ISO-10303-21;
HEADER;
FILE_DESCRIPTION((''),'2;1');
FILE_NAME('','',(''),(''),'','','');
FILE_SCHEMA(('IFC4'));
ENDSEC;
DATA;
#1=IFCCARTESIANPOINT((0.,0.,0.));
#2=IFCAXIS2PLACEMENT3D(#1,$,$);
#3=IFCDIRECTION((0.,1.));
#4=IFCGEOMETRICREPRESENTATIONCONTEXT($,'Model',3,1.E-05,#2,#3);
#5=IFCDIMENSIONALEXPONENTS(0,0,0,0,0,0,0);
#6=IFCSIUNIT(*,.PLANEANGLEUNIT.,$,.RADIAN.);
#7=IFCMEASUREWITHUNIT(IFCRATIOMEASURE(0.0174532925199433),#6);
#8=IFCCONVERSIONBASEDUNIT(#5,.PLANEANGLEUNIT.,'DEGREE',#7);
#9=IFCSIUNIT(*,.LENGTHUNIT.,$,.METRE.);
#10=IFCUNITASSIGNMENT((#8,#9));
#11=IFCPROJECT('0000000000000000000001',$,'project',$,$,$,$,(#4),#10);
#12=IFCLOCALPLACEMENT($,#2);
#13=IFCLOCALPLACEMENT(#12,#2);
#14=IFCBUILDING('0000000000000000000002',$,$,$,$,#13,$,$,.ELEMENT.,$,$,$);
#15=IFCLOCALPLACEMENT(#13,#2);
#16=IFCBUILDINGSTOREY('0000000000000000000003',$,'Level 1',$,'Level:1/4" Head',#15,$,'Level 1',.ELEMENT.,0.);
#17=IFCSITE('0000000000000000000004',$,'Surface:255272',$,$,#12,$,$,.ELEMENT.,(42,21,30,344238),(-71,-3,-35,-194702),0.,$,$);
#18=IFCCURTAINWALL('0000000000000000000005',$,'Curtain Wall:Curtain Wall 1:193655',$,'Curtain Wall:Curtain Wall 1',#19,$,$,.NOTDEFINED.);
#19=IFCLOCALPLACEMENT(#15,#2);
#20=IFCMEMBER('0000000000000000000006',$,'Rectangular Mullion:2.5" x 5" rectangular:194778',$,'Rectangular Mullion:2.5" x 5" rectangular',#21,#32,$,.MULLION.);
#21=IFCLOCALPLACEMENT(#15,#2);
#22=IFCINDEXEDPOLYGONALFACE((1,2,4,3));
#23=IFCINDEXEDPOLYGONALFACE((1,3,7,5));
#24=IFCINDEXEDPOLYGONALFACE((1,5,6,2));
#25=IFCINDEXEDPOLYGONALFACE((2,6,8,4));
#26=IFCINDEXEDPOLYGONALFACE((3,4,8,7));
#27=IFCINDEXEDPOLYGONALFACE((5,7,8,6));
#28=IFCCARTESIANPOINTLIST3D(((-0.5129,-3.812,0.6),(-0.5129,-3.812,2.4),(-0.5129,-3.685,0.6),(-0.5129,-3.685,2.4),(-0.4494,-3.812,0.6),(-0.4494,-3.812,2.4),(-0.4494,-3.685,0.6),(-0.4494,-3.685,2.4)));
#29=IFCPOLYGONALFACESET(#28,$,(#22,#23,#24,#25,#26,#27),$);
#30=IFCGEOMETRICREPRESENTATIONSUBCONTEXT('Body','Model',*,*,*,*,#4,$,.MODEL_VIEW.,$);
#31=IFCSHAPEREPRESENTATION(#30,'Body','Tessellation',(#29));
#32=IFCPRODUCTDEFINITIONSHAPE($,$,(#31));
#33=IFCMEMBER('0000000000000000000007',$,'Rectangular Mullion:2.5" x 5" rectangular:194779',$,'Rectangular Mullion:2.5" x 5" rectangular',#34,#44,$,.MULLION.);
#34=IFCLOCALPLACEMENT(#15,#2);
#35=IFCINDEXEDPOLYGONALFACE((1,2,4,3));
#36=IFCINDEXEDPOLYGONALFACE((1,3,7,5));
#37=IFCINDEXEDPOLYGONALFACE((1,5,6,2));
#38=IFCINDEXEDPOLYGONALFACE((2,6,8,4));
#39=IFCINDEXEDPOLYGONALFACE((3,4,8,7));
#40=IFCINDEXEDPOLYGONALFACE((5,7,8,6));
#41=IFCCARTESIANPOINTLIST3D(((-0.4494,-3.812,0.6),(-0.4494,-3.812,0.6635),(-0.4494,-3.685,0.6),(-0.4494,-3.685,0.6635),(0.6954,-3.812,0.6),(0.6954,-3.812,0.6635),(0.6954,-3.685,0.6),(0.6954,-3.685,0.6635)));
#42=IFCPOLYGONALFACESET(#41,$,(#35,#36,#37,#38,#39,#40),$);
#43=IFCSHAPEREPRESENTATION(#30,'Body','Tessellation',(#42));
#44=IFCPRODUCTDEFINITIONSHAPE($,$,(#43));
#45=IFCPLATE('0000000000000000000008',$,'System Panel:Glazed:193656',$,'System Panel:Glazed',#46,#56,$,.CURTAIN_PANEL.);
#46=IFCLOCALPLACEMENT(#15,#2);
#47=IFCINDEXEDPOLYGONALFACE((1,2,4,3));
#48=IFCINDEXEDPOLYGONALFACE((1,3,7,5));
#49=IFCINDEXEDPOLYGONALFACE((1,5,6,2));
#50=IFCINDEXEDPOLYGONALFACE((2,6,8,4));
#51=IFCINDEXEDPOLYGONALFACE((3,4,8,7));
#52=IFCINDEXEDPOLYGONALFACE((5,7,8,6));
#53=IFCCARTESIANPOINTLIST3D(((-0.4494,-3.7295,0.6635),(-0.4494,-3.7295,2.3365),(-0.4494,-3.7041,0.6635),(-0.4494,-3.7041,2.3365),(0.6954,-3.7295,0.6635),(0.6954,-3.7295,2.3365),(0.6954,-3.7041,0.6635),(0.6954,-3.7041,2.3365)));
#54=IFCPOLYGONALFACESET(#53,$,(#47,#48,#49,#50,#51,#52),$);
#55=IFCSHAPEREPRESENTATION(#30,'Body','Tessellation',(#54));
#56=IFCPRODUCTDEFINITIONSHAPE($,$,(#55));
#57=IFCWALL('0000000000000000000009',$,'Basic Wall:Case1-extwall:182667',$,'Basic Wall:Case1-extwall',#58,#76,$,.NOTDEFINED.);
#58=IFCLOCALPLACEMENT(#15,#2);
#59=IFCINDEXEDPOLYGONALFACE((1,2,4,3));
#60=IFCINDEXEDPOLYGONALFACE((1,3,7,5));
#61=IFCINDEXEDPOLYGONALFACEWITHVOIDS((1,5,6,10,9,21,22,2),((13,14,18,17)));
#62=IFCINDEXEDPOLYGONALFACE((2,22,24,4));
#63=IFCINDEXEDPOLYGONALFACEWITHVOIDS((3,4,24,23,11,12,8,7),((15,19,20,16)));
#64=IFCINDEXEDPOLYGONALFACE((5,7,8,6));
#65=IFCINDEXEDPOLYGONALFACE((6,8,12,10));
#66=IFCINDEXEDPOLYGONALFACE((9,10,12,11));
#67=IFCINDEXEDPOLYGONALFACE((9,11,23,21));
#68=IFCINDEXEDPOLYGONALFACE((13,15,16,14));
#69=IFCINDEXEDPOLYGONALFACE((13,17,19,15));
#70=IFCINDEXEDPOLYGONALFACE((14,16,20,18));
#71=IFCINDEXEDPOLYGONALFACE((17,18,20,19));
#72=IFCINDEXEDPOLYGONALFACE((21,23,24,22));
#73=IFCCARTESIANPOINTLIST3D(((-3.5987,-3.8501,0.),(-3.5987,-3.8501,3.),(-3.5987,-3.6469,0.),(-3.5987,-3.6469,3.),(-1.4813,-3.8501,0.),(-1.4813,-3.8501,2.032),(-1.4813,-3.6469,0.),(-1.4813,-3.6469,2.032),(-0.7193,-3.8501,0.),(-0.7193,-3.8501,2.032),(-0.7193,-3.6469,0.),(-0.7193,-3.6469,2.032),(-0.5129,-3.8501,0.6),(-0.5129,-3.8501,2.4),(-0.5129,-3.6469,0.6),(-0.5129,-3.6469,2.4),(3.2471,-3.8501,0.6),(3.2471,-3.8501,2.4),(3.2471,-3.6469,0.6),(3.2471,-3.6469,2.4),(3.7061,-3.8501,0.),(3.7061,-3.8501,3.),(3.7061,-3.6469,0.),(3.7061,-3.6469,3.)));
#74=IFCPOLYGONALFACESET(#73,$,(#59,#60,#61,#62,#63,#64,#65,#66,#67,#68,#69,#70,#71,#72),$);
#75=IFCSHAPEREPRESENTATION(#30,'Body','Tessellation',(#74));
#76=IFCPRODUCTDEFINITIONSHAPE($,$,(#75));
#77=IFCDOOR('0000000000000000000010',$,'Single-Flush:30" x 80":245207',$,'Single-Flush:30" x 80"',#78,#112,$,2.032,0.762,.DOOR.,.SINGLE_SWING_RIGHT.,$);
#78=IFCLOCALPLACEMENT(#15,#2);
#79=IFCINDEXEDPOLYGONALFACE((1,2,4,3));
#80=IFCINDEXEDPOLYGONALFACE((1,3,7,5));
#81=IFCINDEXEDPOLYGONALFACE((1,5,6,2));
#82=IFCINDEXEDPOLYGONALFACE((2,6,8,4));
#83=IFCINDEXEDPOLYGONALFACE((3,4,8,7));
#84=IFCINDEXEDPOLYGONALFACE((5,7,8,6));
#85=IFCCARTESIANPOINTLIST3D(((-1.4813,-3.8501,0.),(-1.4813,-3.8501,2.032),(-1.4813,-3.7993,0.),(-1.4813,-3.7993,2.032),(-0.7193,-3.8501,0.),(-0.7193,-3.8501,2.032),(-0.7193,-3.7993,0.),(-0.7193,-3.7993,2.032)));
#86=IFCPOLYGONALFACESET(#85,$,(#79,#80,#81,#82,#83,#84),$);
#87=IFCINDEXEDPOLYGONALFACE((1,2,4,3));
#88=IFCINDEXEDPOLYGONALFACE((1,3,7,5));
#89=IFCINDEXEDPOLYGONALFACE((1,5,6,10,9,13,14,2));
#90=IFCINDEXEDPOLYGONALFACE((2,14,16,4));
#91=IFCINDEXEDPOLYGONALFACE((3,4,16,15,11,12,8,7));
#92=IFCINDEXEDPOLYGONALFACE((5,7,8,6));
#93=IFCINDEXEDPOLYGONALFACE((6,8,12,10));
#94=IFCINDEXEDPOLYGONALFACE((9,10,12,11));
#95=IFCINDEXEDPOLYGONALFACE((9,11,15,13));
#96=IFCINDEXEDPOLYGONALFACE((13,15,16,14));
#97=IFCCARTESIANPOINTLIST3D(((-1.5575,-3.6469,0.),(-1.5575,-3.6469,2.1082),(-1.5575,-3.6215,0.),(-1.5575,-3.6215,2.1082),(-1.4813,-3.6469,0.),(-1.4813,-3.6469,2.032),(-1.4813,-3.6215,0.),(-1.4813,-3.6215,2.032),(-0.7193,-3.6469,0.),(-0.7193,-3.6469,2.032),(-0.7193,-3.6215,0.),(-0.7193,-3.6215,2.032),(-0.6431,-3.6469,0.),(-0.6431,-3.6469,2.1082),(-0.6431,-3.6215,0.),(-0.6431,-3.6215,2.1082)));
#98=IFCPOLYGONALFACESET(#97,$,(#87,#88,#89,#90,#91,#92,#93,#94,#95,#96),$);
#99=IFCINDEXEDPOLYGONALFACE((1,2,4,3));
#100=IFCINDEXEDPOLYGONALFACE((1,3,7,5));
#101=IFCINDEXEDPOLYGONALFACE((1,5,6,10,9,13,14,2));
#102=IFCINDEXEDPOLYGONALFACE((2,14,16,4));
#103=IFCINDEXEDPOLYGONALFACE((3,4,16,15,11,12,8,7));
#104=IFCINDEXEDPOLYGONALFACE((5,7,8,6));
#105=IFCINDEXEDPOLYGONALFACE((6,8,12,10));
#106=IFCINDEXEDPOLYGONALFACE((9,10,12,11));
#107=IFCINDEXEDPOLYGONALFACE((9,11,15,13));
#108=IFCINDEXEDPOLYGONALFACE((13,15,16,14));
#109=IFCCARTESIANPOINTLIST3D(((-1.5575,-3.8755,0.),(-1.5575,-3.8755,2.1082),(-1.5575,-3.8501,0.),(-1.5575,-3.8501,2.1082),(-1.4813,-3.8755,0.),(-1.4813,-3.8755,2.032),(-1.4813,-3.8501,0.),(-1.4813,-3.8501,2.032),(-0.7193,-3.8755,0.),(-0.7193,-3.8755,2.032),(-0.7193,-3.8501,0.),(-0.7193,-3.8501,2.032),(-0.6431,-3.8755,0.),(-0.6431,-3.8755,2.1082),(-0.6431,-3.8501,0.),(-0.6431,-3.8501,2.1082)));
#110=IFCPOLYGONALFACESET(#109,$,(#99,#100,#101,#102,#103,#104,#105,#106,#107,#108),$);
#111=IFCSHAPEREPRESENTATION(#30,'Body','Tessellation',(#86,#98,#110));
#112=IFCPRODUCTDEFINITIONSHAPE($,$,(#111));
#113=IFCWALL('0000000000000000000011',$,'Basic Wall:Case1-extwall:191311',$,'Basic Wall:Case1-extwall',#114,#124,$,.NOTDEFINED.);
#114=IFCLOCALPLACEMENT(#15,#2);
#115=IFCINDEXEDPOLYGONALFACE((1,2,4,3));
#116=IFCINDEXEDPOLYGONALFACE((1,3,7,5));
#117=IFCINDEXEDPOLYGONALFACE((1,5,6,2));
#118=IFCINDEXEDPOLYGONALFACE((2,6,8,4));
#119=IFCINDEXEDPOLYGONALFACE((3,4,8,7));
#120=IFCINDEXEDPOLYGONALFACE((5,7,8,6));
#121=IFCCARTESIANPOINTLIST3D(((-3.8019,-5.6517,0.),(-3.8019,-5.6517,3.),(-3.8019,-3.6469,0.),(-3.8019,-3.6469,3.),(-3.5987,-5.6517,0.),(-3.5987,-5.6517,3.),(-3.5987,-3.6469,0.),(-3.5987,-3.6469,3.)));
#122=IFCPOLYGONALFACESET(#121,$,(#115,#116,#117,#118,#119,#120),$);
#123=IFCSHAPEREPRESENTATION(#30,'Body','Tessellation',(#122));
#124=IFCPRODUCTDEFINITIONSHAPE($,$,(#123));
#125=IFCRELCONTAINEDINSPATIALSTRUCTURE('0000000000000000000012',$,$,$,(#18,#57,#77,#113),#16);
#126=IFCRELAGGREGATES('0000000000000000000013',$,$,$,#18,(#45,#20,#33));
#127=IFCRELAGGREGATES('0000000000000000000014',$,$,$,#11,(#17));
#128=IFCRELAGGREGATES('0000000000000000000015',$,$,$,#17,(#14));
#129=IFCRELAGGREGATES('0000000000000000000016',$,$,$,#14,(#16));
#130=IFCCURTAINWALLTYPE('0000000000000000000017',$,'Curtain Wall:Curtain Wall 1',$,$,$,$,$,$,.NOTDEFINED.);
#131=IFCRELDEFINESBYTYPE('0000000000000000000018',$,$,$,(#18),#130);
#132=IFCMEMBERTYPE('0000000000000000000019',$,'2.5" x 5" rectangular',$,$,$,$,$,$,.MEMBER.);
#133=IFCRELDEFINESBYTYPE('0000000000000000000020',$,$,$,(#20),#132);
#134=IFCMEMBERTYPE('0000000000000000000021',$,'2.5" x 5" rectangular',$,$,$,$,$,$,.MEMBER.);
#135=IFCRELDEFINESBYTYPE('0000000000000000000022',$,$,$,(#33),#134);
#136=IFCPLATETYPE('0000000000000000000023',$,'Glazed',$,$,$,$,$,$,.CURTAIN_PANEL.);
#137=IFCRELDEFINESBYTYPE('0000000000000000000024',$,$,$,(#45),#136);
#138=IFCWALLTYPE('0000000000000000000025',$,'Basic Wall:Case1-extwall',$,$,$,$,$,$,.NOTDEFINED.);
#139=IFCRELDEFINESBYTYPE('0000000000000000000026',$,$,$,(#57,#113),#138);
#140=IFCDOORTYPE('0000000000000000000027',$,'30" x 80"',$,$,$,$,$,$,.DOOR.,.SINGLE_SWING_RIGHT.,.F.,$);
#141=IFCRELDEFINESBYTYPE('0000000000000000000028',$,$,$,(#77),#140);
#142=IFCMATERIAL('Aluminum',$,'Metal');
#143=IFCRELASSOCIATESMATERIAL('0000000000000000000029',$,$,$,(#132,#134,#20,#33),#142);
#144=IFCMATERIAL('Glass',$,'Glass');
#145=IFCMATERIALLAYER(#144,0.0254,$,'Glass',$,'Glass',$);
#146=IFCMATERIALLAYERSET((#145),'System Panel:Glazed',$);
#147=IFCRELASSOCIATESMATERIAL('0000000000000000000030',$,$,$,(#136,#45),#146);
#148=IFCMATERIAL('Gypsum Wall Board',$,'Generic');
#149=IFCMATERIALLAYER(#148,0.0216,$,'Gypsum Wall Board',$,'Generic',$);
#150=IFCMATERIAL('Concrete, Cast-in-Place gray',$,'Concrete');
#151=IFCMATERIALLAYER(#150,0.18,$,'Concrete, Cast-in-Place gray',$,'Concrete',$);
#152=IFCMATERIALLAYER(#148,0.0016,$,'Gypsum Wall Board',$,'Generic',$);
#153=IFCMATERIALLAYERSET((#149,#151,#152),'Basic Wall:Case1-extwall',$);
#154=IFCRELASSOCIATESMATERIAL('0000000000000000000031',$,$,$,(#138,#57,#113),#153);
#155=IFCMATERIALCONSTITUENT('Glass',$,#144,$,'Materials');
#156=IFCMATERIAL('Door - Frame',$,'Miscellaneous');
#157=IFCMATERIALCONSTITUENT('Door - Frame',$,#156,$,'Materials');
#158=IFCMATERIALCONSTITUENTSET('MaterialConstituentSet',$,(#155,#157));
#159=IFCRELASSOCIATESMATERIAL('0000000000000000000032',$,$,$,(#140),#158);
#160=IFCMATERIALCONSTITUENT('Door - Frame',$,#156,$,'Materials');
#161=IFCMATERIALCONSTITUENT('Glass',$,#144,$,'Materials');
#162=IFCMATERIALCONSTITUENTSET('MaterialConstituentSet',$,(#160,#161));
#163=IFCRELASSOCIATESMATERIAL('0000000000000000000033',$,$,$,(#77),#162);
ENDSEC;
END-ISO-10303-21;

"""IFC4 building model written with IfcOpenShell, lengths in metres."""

from ifc_helpers import new_model, entity, si_unit, converted_unit, direction, frame, frame_2d, origin, origin_2d_with_axis, place, context, subcontext, project, spatial, polyline, rectangle, outline, extrude, clip, bounded_halfspace, shape, source, transform, mapped, material, layer, layer_set, layer_usage, constituent, constituent_set, material_profile, profile_set, profile_usage, type_object, type_shapes, element, fill, aggregate, save


model = new_model("IFC4")

# Units and contexts
model_context = context("Model", 3, precision=1e-05, world=origin(), true_north=direction((0.0, 1.0)))
body_context = subcontext(model_context, "Body", "Model", "MODEL_VIEW")
footprint_context = subcontext(model_context, "FootPrint", "Model", "MODEL_VIEW")
ifc_project = project(units=[converted_unit("PLANEANGLEUNIT", "DEGREE", entity("IfcRatioMeasure", 0.0174532925199433), si_unit("PLANEANGLEUNIT", "RADIAN"), dimensions=[0, 0, 0, 0, 0, 0, 0]), si_unit("LENGTHUNIT", "METRE")], contexts=[model_context])

# Site, building, storey
site_placement = place(None, origin())
site = spatial("IfcSite", under=ifc_project, at=site_placement, Name="Surface:255272", CompositionType="ELEMENT", RefLatitude=(42, 21, 30, 344238), RefLongitude=(-71, -3, -35, -194702), RefElevation=0.0)
building_placement = place(site_placement, origin())
building = spatial("IfcBuilding", under=site, at=building_placement, CompositionType="ELEMENT")
storey_placement = place(building_placement, origin())
storey = spatial("IfcBuildingStorey", under=building, at=storey_placement, Name="Level 1", ObjectType="Level:1/4\" Head", LongName="Level 1", CompositionType="ELEMENT", Elevation=0.0)

# Curtain wall, member
curtain_wall_type = type_object("IfcCurtainWallType", Name="Curtain Wall:Curtain Wall 1", PredefinedType="NOTDEFINED")
curtain_wall_1_placement = place(storey_placement, origin())
curtain_wall_1 = element("IfcCurtainWall", 1, at=curtain_wall_1_placement, inside=storey, type_object=curtain_wall_type, Name="Curtain Wall:Curtain Wall 1:193655", ObjectType="Curtain Wall:Curtain Wall 1", PredefinedType="NOTDEFINED")
ifc_material_1 = material(Name="Aluminum", Category="Metal")
ifc_material_profile_1 = material_profile(ifc_material_1, rectangle(XDim=0.127, YDim=0.0635, at=origin_2d_with_axis()), Name="2.5\" x 5\" rectangular")
ifc_profile_set_1 = profile_set([ifc_material_profile_1], Name="2.5\" x 5\" rectangular")
ifc_profile_usage_1 = profile_usage(ifc_profile_set_1)
member_type_1 = type_object("IfcMemberType", Name="2.5\" x 5\" rectangular", PredefinedType="MEMBER", material=ifc_profile_set_1)
shared_shape_1 = source(origin(), body_context, "Body", "SweptSolid", [
    extrude(rectangle(XDim=0.127, YDim=0.0635, at=origin_2d_with_axis()), frame((-0.0318, 0.0, -1.8), z_axis=(0.0, 0.0, 1.0), x_axis=(0.0, -1.0, 0.0)), (0.0, 0.0, 1.0), 1.8),
])
type_shapes(member_type_1, [shared_shape_1])
member_1_placement = place(storey_placement, frame((-0.5129, -3.7485, 2.4), z_axis=(0.0, 0.0, 1.0), x_axis=(-1.0, 0.000007, 0.0)))
member_1 = element("IfcMember", 2, at=member_1_placement, type_object=member_type_1, material=ifc_profile_usage_1, Name="Rectangular Mullion:2.5\" x 5\" rectangular:194778", ObjectType="Rectangular Mullion:2.5\" x 5\" rectangular", PredefinedType="MULLION", context=body_context, shape_type="MappedRepresentation", body=[
    mapped(shared_shape_1, transform((0.0, 0.0, 0.0), scale=1.0)),
])

# Member
ifc_profile_usage_2 = profile_usage(ifc_profile_set_1)
member_type_2 = type_object("IfcMemberType", Name="2.5\" x 5\" rectangular", PredefinedType="MEMBER", material=ifc_profile_set_1)
shared_shape_2 = source(origin(), body_context, "Body", "SweptSolid", [
    extrude(rectangle(XDim=0.127, YDim=0.0635, at=origin_2d_with_axis()), frame((-0.0318, 0.0, -1.1447), z_axis=(0.0, 0.0, 1.0), x_axis=(0.0, -1.0, 0.0)), (0.0, 0.0, 1.0), 1.1447),
])
type_shapes(member_type_2, [shared_shape_2])
member_2_placement = place(storey_placement, frame((-0.4494, -3.7485, 0.6), z_axis=(-1.0, 0.000007, 0.0), x_axis=(0.0, 0.0, -1.0)))
member_2 = element("IfcMember", 3, at=member_2_placement, type_object=member_type_2, material=ifc_profile_usage_2, Name="Rectangular Mullion:2.5\" x 5\" rectangular:194779", ObjectType="Rectangular Mullion:2.5\" x 5\" rectangular", PredefinedType="MULLION", context=body_context, shape_type="MappedRepresentation", body=[
    mapped(shared_shape_2, transform((0.0, 0.0, 0.0), scale=1.0)),
])

# Plate
ifc_material_2 = material(Name="Glass", Category="Glass")
ifc_layer_1 = layer(ifc_material_2, 0.0254, Name="Glass", Category="Glass")
ifc_layer_set_1 = layer_set([ifc_layer_1], Name="System Panel:Glazed")
ifc_layer_usage_1 = layer_usage(ifc_layer_set_1, "AXIS3", "POSITIVE", 0.1042)
plate_type_1 = type_object("IfcPlateType", Name="Glazed", PredefinedType="CURTAIN_PANEL", material=ifc_layer_set_1)
shared_shape_3 = source(origin(), body_context, "Body", "SweptSolid", [
    extrude(rectangle(XDim=0.0254, YDim=1.1447, at=frame_2d((0.0, 0.0), x_axis=(1.0, 0.0))), frame((0.5724, 0.0127, 0.0), z_axis=(0.0, 0.0, 1.0), x_axis=(0.0, 1.0, 0.0)), (0.0, 0.0, 1.0), 1.673),
])
cartesian_point_1 = entity("IfcCartesianPoint", [0.7468, 0.0132])
shared_shape_4 = source(frame((-0.5724, 0.0191, 0.0)), footprint_context, "FootPrint", "Curve2D", [
    entity("IfcPolyline", [cartesian_point_1, entity("IfcCartesianPoint", [0.7468, 0.0386]), entity("IfcCartesianPoint", [-0.3979, 0.0386]), entity("IfcCartesianPoint", [-0.3979, 0.0132]), cartesian_point_1]),
])
type_shapes(plate_type_1, [shared_shape_3, shared_shape_4])
plate_1_placement = place(curtain_wall_1_placement, frame((-0.4494, -3.7295, 0.6635)))
plate_1 = element("IfcPlate", 4, at=plate_1_placement, type_object=plate_type_1, material=ifc_layer_usage_1, Name="System Panel:Glazed:193656", ObjectType="System Panel:Glazed", PredefinedType="CURTAIN_PANEL", shapes=[
    shape(body_context, "Body", "MappedRepresentation", [mapped(shared_shape_3, transform((0.0, 0.0, 0.0), scale=1.0))]),
    shape(body_context, "Body", "MappedRepresentation", [mapped(shared_shape_4, transform((0.0, 0.0, 0.0), scale=1.0))]),
])
aggregate(curtain_wall_1, [plate_1, member_1, member_2])

# Wall, opening
ifc_material_3 = material(Name="Gypsum Wall Board", Category="Generic")
ifc_layer_2 = layer(ifc_material_3, 0.0216, Name="Gypsum Wall Board", Category="Generic")
ifc_material_4 = material(Name="Concrete, Cast-in-Place gray", Category="Concrete")
ifc_layer_3 = layer(ifc_material_4, 0.18, Name="Concrete, Cast-in-Place gray", Category="Concrete")
ifc_layer_4 = layer(ifc_material_3, 0.0016, Name="Gypsum Wall Board", Category="Generic")
ifc_layer_set_2 = layer_set([ifc_layer_2, ifc_layer_3, ifc_layer_4], Name="Basic Wall:Case1-extwall")
ifc_layer_usage_2 = layer_usage(ifc_layer_set_2, "AXIS2", "NEGATIVE", 0.1016)
wall_type_1 = type_object("IfcWallType", Name="Basic Wall:Case1-extwall", PredefinedType="NOTDEFINED", material=ifc_layer_set_2)
wall_1_placement = place(storey_placement, frame((-3.5987, -3.7485, 0.0)))
wall_1 = element("IfcWall", 5, at=wall_1_placement, inside=storey, type_object=wall_type_1, material=ifc_layer_usage_2, Name="Basic Wall:Case1-extwall:182667", ObjectType="Basic Wall:Case1-extwall", PredefinedType="NOTDEFINED", context=body_context, shape_type="Clipping", body=[
    clip(extrude(rectangle(XDim=7.3048, YDim=0.2032, at=frame_2d((3.6524, 0.0), x_axis=(-1.0, 0.0))), origin(), (0.0, 0.0, 1.0), 3.0), bounded_halfspace(frame((0.0, -0.1016, 3.0), z_axis=(0.0, 0.0, -1.0), x_axis=(-1.0, 0.0, 0.0)), True, frame((0.0, -0.1016, 3.0)), polyline([(0.0, 0.0), (7.3048, 0.0), (7.3048, 0.2032), (7.1016, 0.2032), (1.4746, 0.2032), (1.3222, 0.2032), (0.0, 0.2032), (0.0, 0.0)]))),
])
opening_1_placement = place(wall_1_placement, frame((3.0859, -0.1016, 0.6)))
opening_1 = element("IfcOpeningElement", 6, at=opening_1_placement, cuts=wall_1, ObjectType="Opening", PredefinedType="OPENING", context=body_context, shape_type="SweptSolid", body=[
    extrude(rectangle(XDim=1.8, YDim=3.76, at=frame_2d((0.0, 0.0), x_axis=(1.0, 0.0))), frame((1.88, 0.0, 0.9), z_axis=(0.0, 1.0, 0.0), x_axis=(0.0, 0.0, -1.0)), (0.0, 0.0, 1.0), 0.2032),
])
fill(opening_1, curtain_wall_1)

# Opening, door
opening_2_placement = place(wall_1_placement, frame((2.8794, 0.1016, 0.0)))
opening_2 = element("IfcOpeningElement", 7, at=opening_2_placement, cuts=wall_1, ObjectType="Opening", PredefinedType="OPENING", context=body_context, shape_type="SweptSolid", body=[
    extrude(rectangle(XDim=0.762, YDim=2.032, at=frame_2d((1.016, 0.381), x_axis=(0.0, 1.0))), frame((0.0, 0.0, 0.0), z_axis=(-0.000007, -1.0, 0.0), x_axis=(0.0, 0.0, 1.0)), (0.0, 0.0, 1.0), 0.2032),
])
ifc_material_5 = material(Name="Door - Frame", Category="Miscellaneous")
ifc_constituent_1 = constituent(ifc_material_5, Name="Door - Frame", Category="Materials")
ifc_constituent_2 = constituent(ifc_material_2, Name="Glass", Category="Materials")
ifc_constituent_set_1 = constituent_set(constituents=[ifc_constituent_1, ifc_constituent_2], Name="MaterialConstituentSet")
ifc_constituent_3 = constituent(ifc_material_2, Name="Glass", Category="Materials")
ifc_constituent_4 = constituent(ifc_material_5, Name="Door - Frame", Category="Materials")
ifc_constituent_set_2 = constituent_set(constituents=[ifc_constituent_3, ifc_constituent_4], Name="MaterialConstituentSet")
door_type = type_object("IfcDoorType", Name="30\" x 80\"", OperationType="SINGLE_SWING_RIGHT", ParameterTakesPrecedence=False, PredefinedType="DOOR", material=ifc_constituent_set_2)
shared_shape_5 = source(origin(), body_context, "Body", "SweptSolid", [
    extrude(rectangle(XDim=0.0508, YDim=0.762, at=frame_2d((0.0, 0.0), x_axis=(1.0, 0.0))), frame((0.381, 0.1778, 0.0), z_axis=(0.0, 0.0, 1.0), x_axis=(0.0, 1.0, 0.0)), (0.0, 0.0, 1.0), 2.032),
    extrude(outline(polyline([(-1.0732, -0.4572), (1.0351, -0.4572), (1.0351, -0.381), (-0.997, -0.381), (-0.997, 0.381), (1.0351, 0.381), (1.0351, 0.4572), (-1.0732, 0.4572), (-1.0732, -0.4572)])), frame((0.381, -0.0254, 1.0351), z_axis=(0.0, 1.0, 0.0), x_axis=(0.0, 0.0, -1.0)), (0.0, 0.0, 1.0), 0.0254),
    extrude(outline(polyline([(-0.4572, -1.0732), (0.4572, -1.0732), (0.4572, 1.0351), (0.381, 1.0351), (0.381, -0.997), (-0.381, -0.997), (-0.381, 1.0351), (-0.4572, 1.0351), (-0.4572, -1.0732)])), frame((0.381, 0.2032, 1.0351), z_axis=(0.0, 1.0, 0.0), x_axis=(1.0, 0.0, 0.0)), (0.0, 0.0, 1.0), 0.0254),
])
type_shapes(door_type, [shared_shape_5])
door_placement = place(opening_2_placement, frame((0.0, 0.0, 0.0), z_axis=(0.0, 0.0, 1.0), x_axis=(-1.0, 0.0, 0.0)))
door = element("IfcDoor", 8, at=door_placement, inside=storey, type_object=door_type, material=ifc_constituent_set_1, Name="Single-Flush:30\" x 80\":245207", ObjectType="Single-Flush:30\" x 80\"", OperationType="SINGLE_SWING_RIGHT", OverallHeight=2.032, OverallWidth=0.762, PredefinedType="DOOR", context=body_context, shape_type="MappedRepresentation", body=[
    mapped(shared_shape_5, transform((0.0, 0.0, 0.0), scale=1.0)),
])
fill(opening_2, door)

# Wall
ifc_layer_usage_3 = layer_usage(ifc_layer_set_2, "AXIS2", "NEGATIVE", 0.1016)
wall_2_placement = place(storey_placement, frame((-3.7003, -3.6469, 0.0), z_axis=(0.0, 0.0, 1.0), x_axis=(-0.000007, -1.0, 0.0)))
element("IfcWall", 9, at=wall_2_placement, inside=storey, type_object=wall_type_1, material=ifc_layer_usage_3, Name="Basic Wall:Case1-extwall:191311", ObjectType="Basic Wall:Case1-extwall", PredefinedType="NOTDEFINED", context=body_context, shape_type="Clipping", body=[
    clip(extrude(rectangle(XDim=2.0048, YDim=0.2032, at=frame_2d((1.0024, 0.0), x_axis=(-1.0, 0.0))), origin(), (0.0, 0.0, 1.0), 3.0), bounded_halfspace(frame((0.0, -0.1016, 3.0), z_axis=(0.0, 0.0, -1.0), x_axis=(0.0, -1.0, 0.0)), True, frame((0.0, -0.1016, 3.0)), polyline([(0.0, 0.0), (1.8016, 0.0), (2.0048, 0.0), (2.0048, 0.2032), (0.2048, 0.2032), (0.2032, 0.2032), (0.0, 0.2032), (0.0, 0.0)]))),
])

save(model, "model.ifc")
